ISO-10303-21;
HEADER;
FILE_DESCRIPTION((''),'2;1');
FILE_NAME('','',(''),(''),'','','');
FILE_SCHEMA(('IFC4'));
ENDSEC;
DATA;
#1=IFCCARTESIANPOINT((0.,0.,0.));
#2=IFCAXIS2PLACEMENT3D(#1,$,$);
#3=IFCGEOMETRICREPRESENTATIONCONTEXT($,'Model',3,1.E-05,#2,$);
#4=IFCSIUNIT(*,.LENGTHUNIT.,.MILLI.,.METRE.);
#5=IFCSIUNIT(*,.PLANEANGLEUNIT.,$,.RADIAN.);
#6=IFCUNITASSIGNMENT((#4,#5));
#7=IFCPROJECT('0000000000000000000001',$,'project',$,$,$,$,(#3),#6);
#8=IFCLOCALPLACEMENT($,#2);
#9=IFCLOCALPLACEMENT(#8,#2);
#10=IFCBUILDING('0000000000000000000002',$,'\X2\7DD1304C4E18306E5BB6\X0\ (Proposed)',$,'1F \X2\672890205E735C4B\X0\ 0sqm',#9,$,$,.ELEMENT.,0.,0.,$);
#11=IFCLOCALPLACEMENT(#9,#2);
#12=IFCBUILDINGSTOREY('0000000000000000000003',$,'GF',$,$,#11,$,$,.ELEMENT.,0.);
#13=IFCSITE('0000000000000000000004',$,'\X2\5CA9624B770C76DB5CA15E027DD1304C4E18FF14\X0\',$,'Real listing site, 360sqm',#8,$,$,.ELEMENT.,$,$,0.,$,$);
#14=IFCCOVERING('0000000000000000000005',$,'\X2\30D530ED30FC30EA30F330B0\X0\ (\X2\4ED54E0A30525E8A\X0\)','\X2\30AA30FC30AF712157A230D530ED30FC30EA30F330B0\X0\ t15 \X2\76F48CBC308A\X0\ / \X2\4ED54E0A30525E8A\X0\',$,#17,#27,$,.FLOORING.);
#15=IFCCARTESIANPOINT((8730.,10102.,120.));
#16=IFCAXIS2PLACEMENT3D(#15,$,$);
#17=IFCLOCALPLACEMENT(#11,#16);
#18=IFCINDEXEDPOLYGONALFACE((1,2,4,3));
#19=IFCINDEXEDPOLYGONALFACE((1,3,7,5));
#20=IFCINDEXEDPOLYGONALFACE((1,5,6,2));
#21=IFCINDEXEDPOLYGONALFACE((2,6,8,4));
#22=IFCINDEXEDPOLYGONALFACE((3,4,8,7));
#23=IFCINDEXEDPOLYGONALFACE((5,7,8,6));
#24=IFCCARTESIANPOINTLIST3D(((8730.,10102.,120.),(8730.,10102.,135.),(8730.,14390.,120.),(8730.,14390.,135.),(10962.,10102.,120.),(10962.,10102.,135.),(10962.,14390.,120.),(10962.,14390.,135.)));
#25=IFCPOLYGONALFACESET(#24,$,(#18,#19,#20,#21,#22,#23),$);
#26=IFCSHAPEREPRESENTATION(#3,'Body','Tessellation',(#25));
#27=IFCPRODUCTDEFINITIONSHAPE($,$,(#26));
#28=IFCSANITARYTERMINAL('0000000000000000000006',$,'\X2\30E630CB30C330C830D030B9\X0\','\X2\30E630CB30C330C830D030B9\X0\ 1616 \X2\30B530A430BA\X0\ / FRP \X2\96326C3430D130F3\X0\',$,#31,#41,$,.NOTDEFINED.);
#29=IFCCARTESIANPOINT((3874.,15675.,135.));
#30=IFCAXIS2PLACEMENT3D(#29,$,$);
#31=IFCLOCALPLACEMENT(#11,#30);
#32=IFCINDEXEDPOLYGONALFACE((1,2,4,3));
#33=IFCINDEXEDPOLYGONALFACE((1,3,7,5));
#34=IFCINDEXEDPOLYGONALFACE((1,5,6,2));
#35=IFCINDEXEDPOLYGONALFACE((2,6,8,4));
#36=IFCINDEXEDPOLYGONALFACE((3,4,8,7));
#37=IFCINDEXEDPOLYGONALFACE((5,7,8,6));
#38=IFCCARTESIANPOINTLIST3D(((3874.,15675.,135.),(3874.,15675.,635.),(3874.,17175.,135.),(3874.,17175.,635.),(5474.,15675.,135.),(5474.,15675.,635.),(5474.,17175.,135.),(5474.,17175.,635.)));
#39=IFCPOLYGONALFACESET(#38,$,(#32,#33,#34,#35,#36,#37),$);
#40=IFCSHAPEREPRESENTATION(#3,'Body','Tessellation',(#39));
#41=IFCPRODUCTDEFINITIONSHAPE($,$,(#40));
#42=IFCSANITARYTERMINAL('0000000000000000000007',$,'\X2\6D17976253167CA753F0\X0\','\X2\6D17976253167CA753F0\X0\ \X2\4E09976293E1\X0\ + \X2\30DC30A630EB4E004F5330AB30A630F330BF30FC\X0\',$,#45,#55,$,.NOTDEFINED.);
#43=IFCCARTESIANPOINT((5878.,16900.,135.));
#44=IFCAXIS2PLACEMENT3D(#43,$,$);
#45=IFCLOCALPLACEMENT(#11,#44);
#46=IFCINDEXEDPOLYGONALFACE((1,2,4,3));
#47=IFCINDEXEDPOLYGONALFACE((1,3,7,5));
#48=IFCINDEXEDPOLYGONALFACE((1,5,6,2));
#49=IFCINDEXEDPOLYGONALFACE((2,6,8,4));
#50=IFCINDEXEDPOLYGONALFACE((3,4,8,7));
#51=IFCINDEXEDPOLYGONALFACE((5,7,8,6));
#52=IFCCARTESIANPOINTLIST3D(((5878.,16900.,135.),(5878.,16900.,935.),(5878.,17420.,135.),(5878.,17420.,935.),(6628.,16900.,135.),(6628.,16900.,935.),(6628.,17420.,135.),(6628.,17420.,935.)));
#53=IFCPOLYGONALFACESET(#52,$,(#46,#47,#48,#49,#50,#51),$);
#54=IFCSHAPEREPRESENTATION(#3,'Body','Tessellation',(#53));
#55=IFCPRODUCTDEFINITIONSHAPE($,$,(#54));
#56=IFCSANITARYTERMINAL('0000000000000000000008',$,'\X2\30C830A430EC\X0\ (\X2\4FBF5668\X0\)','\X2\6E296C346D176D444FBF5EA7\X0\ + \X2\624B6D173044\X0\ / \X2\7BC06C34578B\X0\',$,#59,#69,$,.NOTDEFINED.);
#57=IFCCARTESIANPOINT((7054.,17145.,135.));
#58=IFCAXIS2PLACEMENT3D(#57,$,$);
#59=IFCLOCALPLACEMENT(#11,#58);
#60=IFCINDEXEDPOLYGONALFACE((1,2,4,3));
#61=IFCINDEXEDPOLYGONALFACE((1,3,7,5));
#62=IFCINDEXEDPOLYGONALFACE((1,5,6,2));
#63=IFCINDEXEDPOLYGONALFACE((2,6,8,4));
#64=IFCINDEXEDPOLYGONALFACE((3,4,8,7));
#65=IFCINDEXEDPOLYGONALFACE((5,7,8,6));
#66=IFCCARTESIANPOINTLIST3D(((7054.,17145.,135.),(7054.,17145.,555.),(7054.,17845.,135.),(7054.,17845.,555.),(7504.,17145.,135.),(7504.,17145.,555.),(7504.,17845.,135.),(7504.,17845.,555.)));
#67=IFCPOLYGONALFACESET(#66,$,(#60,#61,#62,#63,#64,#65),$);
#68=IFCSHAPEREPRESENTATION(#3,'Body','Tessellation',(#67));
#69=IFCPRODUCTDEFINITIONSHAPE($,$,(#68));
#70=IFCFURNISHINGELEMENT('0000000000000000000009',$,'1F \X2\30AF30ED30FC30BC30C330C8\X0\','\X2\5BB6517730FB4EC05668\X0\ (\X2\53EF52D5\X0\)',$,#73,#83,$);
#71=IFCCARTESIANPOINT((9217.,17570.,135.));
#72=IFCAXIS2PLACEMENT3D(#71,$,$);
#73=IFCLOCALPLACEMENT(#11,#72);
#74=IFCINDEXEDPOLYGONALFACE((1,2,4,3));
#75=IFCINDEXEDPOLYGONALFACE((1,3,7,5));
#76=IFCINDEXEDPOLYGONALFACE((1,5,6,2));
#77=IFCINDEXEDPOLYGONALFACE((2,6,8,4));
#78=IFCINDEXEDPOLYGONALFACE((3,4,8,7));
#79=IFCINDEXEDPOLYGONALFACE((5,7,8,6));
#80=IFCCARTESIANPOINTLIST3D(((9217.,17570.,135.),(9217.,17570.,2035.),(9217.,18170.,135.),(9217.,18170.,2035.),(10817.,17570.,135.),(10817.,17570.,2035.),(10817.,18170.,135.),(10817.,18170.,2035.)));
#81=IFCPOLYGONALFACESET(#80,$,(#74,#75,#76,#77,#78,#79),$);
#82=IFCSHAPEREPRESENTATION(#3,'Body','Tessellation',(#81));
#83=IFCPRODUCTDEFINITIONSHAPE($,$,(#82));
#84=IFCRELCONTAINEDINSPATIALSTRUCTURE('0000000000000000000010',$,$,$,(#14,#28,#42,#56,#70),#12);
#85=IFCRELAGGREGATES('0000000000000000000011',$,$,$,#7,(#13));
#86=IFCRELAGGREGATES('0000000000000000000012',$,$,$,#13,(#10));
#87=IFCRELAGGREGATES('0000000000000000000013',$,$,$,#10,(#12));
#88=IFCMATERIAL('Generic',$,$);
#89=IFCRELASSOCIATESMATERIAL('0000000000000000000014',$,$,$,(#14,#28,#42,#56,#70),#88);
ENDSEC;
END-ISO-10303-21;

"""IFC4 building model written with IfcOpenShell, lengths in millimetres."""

from ifc_helpers import new_model, si_unit, frame, frame_2d, origin, place, context, project, spatial, rectangle, extrude, material, element, save


model = new_model("IFC4")

# Units and contexts
model_context = context("Model", 3, precision=1e-05, world=origin())
ifc_project = project(units=[si_unit("LENGTHUNIT", "METRE", prefix="MILLI"), si_unit("PLANEANGLEUNIT", "RADIAN")], contexts=[model_context])

# Site, building, storey
site_placement = place(None, origin())
site = spatial("IfcSite", under=ifc_project, at=site_placement, Name="岩手県盛岡市緑が丘４", ObjectType="Real listing site, 360sqm", CompositionType="ELEMENT", RefElevation=0.0)
building_placement = place(site_placement, origin())
building = spatial("IfcBuilding", under=site, at=building_placement, Name="緑が丘の家 (Proposed)", ObjectType="1F 木造平屋 0sqm", CompositionType="ELEMENT", ElevationOfRefHeight=0.0, ElevationOfTerrain=0.0)
storey_placement = place(building_placement, origin())
storey = spatial("IfcBuildingStorey", under=building, at=storey_placement, Name="GF", CompositionType="ELEMENT", Elevation=0.0)

# Covering
ifc_material_1 = material(Name="Generic")
covering_1_placement = place(storey_placement, frame((8730.0, 10102.0, 120.0)))
element("IfcCovering", 1, at=covering_1_placement, inside=storey, material=ifc_material_1, Name="フローリング (仕上げ床)", Description="オーク無垢フローリング t15 直貼り / 仕上げ床", PredefinedType="FLOORING", context=model_context, shape_type="SweptSolid", body=[
    extrude(rectangle(XDim=2232.0, YDim=4288.0, at=frame_2d((1116.0, 2144.0))), frame((8730.0, 10102.0, 120.0)), (0.0, 0.0, 1.0), 15.0),
])

# Sanitary terminals
sanitary_terminal_1_placement = place(storey_placement, frame((3874.0, 15675.0, 135.0)))
element("IfcSanitaryTerminal", 2, at=sanitary_terminal_1_placement, inside=storey, material=ifc_material_1, Name="ユニットバス", Description="ユニットバス 1616 サイズ / FRP 防水パン", PredefinedType="NOTDEFINED", context=model_context, shape_type="SweptSolid", body=[
    extrude(rectangle(XDim=1600.0, YDim=1500.0, at=frame_2d((800.0, 750.0))), frame((3874.0, 15675.0, 135.0)), (0.0, 0.0, 1.0), 500.0),
])
sanitary_terminal_2_placement = place(storey_placement, frame((5878.0, 16900.0, 135.0)))
element("IfcSanitaryTerminal", 3, at=sanitary_terminal_2_placement, inside=storey, material=ifc_material_1, Name="洗面化粧台", Description="洗面化粧台 三面鏡 + ボウル一体カウンター", PredefinedType="NOTDEFINED", context=model_context, shape_type="SweptSolid", body=[
    extrude(rectangle(XDim=750.0, YDim=520.0, at=frame_2d((375.0, 260.0))), frame((5878.0, 16900.0, 135.0)), (0.0, 0.0, 1.0), 800.0),
])
sanitary_terminal_3_placement = place(storey_placement, frame((7054.0, 17145.0, 135.0)))
element("IfcSanitaryTerminal", 4, at=sanitary_terminal_3_placement, inside=storey, material=ifc_material_1, Name="トイレ (便器)", Description="温水洗浄便座 + 手洗い / 節水型", PredefinedType="NOTDEFINED", context=model_context, shape_type="SweptSolid", body=[
    extrude(rectangle(XDim=450.0, YDim=700.0, at=frame_2d((225.0, 350.0))), frame((7054.0, 17145.0, 135.0)), (0.0, 0.0, 1.0), 420.0),
])

# Furnishing element
furnishing_placement = place(storey_placement, frame((9217.0, 17570.0, 135.0)))
element("IfcFurnishingElement", 5, at=furnishing_placement, inside=storey, material=ifc_material_1, Name="1F クローゼット", Description="家具・什器 (可動)", context=model_context, shape_type="SweptSolid", body=[
    extrude(rectangle(XDim=1600.0, YDim=600.0, at=frame_2d((800.0, 300.0))), frame((9217.0, 17570.0, 135.0)), (0.0, 0.0, 1.0), 1900.0),
])

save(model, "model.ifc")
